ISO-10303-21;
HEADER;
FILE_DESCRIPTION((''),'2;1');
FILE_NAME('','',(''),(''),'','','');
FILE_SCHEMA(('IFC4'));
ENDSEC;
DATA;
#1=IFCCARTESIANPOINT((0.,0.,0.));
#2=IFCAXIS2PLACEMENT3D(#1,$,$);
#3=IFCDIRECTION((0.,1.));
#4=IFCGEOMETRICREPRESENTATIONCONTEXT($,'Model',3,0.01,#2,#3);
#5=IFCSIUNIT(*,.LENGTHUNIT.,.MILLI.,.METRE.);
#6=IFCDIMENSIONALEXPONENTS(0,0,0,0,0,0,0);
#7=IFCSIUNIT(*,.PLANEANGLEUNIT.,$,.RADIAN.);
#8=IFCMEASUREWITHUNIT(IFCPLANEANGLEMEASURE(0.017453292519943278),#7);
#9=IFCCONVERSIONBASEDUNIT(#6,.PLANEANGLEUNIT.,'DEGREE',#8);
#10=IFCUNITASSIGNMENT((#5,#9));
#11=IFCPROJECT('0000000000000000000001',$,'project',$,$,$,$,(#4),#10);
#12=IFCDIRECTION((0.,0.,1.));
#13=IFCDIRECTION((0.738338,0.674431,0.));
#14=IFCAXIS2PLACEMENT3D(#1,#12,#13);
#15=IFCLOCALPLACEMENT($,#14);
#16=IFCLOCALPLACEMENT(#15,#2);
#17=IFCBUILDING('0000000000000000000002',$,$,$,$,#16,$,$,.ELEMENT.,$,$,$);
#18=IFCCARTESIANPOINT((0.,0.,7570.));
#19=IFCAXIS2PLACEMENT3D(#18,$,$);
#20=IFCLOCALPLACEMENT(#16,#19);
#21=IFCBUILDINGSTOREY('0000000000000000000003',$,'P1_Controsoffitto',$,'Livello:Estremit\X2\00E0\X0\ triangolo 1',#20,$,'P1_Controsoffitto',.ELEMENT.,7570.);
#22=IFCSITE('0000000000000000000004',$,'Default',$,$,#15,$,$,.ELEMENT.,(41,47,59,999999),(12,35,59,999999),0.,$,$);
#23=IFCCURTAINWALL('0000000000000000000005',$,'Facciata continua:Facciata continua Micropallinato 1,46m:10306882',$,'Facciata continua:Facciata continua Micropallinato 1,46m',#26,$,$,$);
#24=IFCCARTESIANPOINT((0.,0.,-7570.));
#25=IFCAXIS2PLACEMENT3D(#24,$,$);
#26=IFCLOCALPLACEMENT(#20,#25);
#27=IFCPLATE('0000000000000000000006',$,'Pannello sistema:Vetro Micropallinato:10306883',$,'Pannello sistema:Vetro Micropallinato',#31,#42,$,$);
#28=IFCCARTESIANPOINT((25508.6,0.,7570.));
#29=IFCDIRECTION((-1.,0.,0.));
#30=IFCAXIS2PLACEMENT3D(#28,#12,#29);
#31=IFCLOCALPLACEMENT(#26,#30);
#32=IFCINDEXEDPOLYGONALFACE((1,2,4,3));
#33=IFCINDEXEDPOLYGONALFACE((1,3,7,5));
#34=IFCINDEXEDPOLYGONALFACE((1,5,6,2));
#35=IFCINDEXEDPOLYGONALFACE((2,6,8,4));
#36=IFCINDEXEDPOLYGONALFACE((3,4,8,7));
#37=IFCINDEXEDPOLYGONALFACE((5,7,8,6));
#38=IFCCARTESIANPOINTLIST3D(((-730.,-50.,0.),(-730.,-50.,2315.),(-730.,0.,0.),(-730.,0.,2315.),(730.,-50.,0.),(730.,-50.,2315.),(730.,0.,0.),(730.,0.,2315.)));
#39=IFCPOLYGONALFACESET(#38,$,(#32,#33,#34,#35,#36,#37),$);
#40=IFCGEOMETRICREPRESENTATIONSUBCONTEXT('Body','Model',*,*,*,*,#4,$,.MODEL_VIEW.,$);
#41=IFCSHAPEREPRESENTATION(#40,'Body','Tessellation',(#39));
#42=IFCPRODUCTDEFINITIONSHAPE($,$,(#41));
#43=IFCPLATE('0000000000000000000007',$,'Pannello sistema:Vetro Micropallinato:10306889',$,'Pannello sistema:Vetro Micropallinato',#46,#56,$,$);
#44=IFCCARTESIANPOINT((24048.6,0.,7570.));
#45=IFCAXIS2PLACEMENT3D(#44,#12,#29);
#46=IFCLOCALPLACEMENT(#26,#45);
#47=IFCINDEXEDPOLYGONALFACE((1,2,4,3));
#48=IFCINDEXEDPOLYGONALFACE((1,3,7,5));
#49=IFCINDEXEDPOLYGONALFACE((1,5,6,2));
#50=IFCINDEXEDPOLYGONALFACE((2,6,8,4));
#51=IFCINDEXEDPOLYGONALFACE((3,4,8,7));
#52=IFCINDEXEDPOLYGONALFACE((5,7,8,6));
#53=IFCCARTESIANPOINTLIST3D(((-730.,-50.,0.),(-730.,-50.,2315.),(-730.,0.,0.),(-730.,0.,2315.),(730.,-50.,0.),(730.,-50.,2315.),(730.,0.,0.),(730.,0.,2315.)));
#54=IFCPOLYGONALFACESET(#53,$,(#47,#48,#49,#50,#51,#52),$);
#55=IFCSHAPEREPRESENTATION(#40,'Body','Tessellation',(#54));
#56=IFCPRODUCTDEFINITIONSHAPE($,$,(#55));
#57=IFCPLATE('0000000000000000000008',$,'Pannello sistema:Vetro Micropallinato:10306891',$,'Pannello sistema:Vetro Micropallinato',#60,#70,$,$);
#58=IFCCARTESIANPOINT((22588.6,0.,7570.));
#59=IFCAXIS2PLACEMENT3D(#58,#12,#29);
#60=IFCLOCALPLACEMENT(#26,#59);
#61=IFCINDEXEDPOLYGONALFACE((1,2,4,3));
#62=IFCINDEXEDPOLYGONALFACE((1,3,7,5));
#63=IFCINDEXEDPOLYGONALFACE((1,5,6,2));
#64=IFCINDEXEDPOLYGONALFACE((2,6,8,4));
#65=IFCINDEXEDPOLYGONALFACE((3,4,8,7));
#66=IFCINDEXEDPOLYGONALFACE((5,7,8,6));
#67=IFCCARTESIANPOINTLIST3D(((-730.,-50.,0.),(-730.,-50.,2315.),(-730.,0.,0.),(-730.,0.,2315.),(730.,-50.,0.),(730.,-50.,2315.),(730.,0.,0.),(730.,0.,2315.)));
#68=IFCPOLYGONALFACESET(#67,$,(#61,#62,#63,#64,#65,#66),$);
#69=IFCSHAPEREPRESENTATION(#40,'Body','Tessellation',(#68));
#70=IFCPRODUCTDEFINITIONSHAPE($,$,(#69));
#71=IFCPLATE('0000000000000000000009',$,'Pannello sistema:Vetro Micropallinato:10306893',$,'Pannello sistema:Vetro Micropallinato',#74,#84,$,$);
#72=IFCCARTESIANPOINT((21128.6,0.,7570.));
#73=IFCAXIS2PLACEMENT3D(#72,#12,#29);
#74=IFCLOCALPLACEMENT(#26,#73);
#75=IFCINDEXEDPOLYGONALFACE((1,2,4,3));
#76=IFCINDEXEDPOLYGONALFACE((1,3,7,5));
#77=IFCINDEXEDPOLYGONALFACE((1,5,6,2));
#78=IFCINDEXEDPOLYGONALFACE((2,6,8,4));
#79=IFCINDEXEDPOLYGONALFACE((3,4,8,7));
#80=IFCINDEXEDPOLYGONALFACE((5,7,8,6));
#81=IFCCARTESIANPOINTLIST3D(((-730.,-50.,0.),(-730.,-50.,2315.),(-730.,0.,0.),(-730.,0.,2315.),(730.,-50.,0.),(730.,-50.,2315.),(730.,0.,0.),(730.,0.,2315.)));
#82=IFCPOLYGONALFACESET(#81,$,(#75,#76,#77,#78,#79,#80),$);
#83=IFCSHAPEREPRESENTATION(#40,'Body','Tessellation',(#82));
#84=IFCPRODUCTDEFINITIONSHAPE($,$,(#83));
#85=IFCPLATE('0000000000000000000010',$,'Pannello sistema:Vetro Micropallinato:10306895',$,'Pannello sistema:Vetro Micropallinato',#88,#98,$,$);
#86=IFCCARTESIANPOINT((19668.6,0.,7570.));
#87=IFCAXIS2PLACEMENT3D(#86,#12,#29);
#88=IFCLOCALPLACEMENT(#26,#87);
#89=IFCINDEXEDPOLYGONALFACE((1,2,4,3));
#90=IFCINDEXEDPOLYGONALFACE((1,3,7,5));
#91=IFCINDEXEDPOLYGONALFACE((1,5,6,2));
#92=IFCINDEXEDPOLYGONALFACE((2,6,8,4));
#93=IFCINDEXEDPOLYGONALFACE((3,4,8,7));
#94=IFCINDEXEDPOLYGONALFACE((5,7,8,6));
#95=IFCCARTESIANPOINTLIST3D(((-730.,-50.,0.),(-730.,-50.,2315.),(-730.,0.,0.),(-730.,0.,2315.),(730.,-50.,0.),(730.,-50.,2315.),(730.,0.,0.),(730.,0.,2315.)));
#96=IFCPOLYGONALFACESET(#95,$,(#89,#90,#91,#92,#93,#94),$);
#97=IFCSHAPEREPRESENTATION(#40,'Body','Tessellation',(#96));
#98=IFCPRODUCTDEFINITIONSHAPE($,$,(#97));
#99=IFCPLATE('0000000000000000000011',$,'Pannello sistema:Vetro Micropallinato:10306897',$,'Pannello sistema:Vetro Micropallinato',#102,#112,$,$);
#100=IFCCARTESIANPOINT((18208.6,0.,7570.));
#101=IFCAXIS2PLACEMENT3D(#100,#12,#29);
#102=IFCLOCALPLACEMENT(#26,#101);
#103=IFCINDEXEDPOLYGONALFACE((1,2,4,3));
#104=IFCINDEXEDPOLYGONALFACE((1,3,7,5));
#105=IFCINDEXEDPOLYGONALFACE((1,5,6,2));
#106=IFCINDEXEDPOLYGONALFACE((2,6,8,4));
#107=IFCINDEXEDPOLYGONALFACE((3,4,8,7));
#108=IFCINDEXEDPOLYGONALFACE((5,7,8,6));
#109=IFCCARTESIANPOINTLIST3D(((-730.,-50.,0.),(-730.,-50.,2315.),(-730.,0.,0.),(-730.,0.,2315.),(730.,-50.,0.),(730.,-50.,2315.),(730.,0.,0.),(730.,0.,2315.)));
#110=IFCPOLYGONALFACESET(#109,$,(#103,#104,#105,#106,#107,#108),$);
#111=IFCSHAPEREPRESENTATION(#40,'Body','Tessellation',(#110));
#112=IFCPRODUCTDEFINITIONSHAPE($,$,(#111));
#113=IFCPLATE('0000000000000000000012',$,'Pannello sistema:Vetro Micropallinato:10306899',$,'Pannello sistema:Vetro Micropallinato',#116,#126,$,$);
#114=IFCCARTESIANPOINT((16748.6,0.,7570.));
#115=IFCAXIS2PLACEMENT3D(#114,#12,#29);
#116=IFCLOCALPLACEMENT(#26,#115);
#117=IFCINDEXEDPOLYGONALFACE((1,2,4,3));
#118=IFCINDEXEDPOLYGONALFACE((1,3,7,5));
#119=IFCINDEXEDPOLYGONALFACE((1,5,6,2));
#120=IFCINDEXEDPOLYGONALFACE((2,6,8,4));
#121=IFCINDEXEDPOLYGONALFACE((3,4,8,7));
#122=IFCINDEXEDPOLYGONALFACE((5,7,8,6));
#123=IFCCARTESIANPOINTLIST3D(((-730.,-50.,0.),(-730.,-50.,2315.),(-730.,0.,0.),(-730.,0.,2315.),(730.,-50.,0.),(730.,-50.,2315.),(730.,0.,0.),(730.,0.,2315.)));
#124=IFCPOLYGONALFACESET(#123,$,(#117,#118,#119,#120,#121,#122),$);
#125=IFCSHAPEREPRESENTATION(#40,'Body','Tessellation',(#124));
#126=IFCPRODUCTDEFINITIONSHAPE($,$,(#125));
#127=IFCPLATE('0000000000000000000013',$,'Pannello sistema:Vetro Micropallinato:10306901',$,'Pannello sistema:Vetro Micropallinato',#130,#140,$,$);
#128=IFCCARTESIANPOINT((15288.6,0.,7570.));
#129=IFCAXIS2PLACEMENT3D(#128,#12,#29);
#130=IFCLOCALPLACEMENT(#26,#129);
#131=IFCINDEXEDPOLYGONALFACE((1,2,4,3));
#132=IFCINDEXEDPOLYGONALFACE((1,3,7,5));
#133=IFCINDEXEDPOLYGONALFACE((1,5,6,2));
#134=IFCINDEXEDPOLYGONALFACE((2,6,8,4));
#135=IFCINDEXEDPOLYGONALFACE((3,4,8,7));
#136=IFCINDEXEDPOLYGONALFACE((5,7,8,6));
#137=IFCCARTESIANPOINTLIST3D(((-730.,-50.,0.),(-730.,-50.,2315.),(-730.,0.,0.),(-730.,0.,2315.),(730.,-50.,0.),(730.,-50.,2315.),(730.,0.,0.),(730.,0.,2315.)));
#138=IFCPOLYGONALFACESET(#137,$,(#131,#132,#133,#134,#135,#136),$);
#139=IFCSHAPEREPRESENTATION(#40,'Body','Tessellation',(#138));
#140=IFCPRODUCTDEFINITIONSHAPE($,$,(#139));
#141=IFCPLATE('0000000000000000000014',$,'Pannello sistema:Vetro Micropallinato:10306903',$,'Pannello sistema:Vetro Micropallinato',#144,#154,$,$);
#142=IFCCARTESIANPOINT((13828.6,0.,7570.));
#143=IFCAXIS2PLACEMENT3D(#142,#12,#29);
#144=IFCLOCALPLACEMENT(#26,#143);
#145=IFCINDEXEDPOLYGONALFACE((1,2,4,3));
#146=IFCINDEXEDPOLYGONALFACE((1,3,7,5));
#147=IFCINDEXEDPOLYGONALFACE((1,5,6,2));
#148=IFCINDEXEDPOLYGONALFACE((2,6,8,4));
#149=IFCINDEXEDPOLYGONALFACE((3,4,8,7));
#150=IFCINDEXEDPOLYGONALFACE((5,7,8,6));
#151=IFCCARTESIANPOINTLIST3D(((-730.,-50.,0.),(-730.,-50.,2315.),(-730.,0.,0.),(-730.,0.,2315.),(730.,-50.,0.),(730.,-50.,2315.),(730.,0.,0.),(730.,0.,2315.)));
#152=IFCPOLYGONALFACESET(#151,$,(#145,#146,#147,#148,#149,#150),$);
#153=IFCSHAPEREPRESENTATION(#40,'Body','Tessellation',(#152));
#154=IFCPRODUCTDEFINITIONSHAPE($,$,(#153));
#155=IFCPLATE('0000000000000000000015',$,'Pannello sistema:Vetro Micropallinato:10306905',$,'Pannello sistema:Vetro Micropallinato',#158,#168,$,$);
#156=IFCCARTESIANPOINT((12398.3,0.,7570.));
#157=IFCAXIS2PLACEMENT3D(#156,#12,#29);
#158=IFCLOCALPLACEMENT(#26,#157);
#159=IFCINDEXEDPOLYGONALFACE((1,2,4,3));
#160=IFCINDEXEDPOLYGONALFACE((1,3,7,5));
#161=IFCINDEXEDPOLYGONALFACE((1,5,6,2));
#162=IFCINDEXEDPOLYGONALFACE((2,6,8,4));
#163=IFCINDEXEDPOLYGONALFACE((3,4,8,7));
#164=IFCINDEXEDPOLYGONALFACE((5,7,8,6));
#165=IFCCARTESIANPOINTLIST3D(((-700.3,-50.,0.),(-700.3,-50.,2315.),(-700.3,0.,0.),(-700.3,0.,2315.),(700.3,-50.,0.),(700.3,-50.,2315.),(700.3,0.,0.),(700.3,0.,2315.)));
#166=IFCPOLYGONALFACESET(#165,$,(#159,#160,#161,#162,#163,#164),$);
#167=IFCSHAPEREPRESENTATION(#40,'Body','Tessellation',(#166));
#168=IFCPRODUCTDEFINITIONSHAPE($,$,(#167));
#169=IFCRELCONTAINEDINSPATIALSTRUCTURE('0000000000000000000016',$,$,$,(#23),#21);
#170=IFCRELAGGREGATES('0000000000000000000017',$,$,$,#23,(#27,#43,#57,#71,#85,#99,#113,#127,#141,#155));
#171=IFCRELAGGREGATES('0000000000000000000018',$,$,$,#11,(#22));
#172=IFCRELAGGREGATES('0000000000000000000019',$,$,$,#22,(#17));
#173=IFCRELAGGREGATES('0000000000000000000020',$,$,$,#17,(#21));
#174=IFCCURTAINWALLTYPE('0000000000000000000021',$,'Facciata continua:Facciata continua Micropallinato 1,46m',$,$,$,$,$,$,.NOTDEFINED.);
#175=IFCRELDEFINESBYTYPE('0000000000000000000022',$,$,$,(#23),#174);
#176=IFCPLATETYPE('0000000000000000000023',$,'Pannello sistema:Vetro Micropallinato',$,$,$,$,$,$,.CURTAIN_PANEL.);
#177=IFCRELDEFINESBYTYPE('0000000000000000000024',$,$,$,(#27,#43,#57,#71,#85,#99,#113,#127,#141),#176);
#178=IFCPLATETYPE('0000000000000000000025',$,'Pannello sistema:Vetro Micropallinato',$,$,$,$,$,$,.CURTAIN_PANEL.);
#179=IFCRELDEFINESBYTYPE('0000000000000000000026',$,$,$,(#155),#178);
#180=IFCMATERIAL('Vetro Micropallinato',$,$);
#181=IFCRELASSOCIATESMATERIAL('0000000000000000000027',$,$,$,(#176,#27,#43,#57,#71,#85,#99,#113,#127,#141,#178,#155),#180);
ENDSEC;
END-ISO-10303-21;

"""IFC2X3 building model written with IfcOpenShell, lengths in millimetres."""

from ifc_helpers import new_model, entity, si_unit, converted_unit, direction, frame, origin, origin_2d_with_axis, place, context, subcontext, project, spatial, rectangle, extrude, source, transform, mapped, material, type_object, type_shapes, element, aggregate, save


model = new_model("IFC2X3")

# Units and contexts
model_context = context("Model", 3, precision=0.01, world=origin(), true_north=direction((0.0, 1.0)))
body_context = subcontext(model_context, "Body", "Model", "MODEL_VIEW")
ifc_project = project(units=[si_unit("LENGTHUNIT", "METRE", prefix="MILLI"), converted_unit("PLANEANGLEUNIT", "DEGREE", entity("IfcPlaneAngleMeasure", 0.017453292519943278), si_unit("PLANEANGLEUNIT", "RADIAN"), dimensions=[0, 0, 0, 0, 0, 0, 0])], contexts=[model_context])

# Site, building, storey
site_placement = place(None, frame((0.0, 0.0, 0.0), z_axis=(0.0, 0.0, 1.0), x_axis=(0.738338, 0.674431, 0.0)))
site = spatial("IfcSite", under=ifc_project, at=site_placement, Name="Default", CompositionType="ELEMENT", RefLatitude=(41, 47, 59, 999999), RefLongitude=(12, 35, 59, 999999), RefElevation=0.0)
building_placement = place(site_placement, origin())
building = spatial("IfcBuilding", under=site, at=building_placement, CompositionType="ELEMENT")
storey_placement = place(building_placement, frame((0.0, 0.0, 7570.0)))
storey = spatial("IfcBuildingStorey", under=building, at=storey_placement, Name="P1_Controsoffitto", ObjectType="Livello:Estremità triangolo 1", LongName="P1_Controsoffitto", CompositionType="ELEMENT", Elevation=7570.0)

# Curtain wall, plates
curtain_wall_type = type_object("IfcCurtainWallType", Name="Facciata continua:Facciata continua Micropallinato 1,46m", PredefinedType="NOTDEFINED")
curtain_wall_placement = place(storey_placement, frame((0.0, 0.0, -7570.0)))
curtain_wall = element("IfcCurtainWall", 1, at=curtain_wall_placement, inside=storey, type_object=curtain_wall_type, Name="Facciata continua:Facciata continua Micropallinato 1,46m:10306882", ObjectType="Facciata continua:Facciata continua Micropallinato 1,46m")
ifc_material_1 = material(Name="Vetro Micropallinato")
plate_type_1 = type_object("IfcPlateType", Name="Pannello sistema:Vetro Micropallinato", PredefinedType="CURTAIN_PANEL", material=ifc_material_1)
shared_shape_1 = source(origin(), body_context, "Body", "SweptSolid", [
    extrude(rectangle(XDim=50.0, YDim=1460.0, at=origin_2d_with_axis()), frame((0.0, -25.0, 0.0), z_axis=(0.0, 0.0, 1.0), x_axis=(0.0, 1.0, 0.0)), (0.0, 0.0, 1.0), 2315.0),
])
type_shapes(plate_type_1, [shared_shape_1])
plate_1_placement = place(curtain_wall_placement, frame((25508.6, 0.0, 7570.0), z_axis=(0.0, 0.0, 1.0), x_axis=(-1.0, 0.0, 0.0)))
plate_1 = element("IfcPlate", 2, at=plate_1_placement, type_object=plate_type_1, material=ifc_material_1, Name="Pannello sistema:Vetro Micropallinato:10306883", ObjectType="Pannello sistema:Vetro Micropallinato", context=body_context, shape_type="MappedRepresentation", body=[
    mapped(shared_shape_1, transform((0.0, 0.0, 0.0), scale=1.0)),
])
plate_2_placement = place(curtain_wall_placement, frame((24048.6, 0.0, 7570.0), z_axis=(0.0, 0.0, 1.0), x_axis=(-1.0, 0.0, 0.0)))
plate_2 = element("IfcPlate", 3, at=plate_2_placement, type_object=plate_type_1, material=ifc_material_1, Name="Pannello sistema:Vetro Micropallinato:10306889", ObjectType="Pannello sistema:Vetro Micropallinato", context=body_context, shape_type="MappedRepresentation", body=[
    mapped(shared_shape_1, transform((0.0, 0.0, 0.0), scale=1.0)),
])
plate_3_placement = place(curtain_wall_placement, frame((22588.6, 0.0, 7570.0), z_axis=(0.0, 0.0, 1.0), x_axis=(-1.0, 0.0, 0.0)))
plate_3 = element("IfcPlate", 4, at=plate_3_placement, type_object=plate_type_1, material=ifc_material_1, Name="Pannello sistema:Vetro Micropallinato:10306891", ObjectType="Pannello sistema:Vetro Micropallinato", context=body_context, shape_type="MappedRepresentation", body=[
    mapped(shared_shape_1, transform((0.0, 0.0, 0.0), scale=1.0)),
])
plate_4_placement = place(curtain_wall_placement, frame((21128.6, 0.0, 7570.0), z_axis=(0.0, 0.0, 1.0), x_axis=(-1.0, 0.0, 0.0)))
plate_4 = element("IfcPlate", 5, at=plate_4_placement, type_object=plate_type_1, material=ifc_material_1, Name="Pannello sistema:Vetro Micropallinato:10306893", ObjectType="Pannello sistema:Vetro Micropallinato", context=body_context, shape_type="MappedRepresentation", body=[
    mapped(shared_shape_1, transform((0.0, 0.0, 0.0), scale=1.0)),
])
plate_5_placement = place(curtain_wall_placement, frame((19668.6, 0.0, 7570.0), z_axis=(0.0, 0.0, 1.0), x_axis=(-1.0, 0.0, 0.0)))
plate_5 = element("IfcPlate", 6, at=plate_5_placement, type_object=plate_type_1, material=ifc_material_1, Name="Pannello sistema:Vetro Micropallinato:10306895", ObjectType="Pannello sistema:Vetro Micropallinato", context=body_context, shape_type="MappedRepresentation", body=[
    mapped(shared_shape_1, transform((0.0, 0.0, 0.0), scale=1.0)),
])
plate_6_placement = place(curtain_wall_placement, frame((18208.6, 0.0, 7570.0), z_axis=(0.0, 0.0, 1.0), x_axis=(-1.0, 0.0, 0.0)))
plate_6 = element("IfcPlate", 7, at=plate_6_placement, type_object=plate_type_1, material=ifc_material_1, Name="Pannello sistema:Vetro Micropallinato:10306897", ObjectType="Pannello sistema:Vetro Micropallinato", context=body_context, shape_type="MappedRepresentation", body=[
    mapped(shared_shape_1, transform((0.0, 0.0, 0.0), scale=1.0)),
])
plate_7_placement = place(curtain_wall_placement, frame((16748.6, 0.0, 7570.0), z_axis=(0.0, 0.0, 1.0), x_axis=(-1.0, 0.0, 0.0)))
plate_7 = element("IfcPlate", 8, at=plate_7_placement, type_object=plate_type_1, material=ifc_material_1, Name="Pannello sistema:Vetro Micropallinato:10306899", ObjectType="Pannello sistema:Vetro Micropallinato", context=body_context, shape_type="MappedRepresentation", body=[
    mapped(shared_shape_1, transform((0.0, 0.0, 0.0), scale=1.0)),
])
plate_8_placement = place(curtain_wall_placement, frame((15288.6, 0.0, 7570.0), z_axis=(0.0, 0.0, 1.0), x_axis=(-1.0, 0.0, 0.0)))
plate_8 = element("IfcPlate", 9, at=plate_8_placement, type_object=plate_type_1, material=ifc_material_1, Name="Pannello sistema:Vetro Micropallinato:10306901", ObjectType="Pannello sistema:Vetro Micropallinato", context=body_context, shape_type="MappedRepresentation", body=[
    mapped(shared_shape_1, transform((0.0, 0.0, 0.0), scale=1.0)),
])
plate_9_placement = place(curtain_wall_placement, frame((13828.6, 0.0, 7570.0), z_axis=(0.0, 0.0, 1.0), x_axis=(-1.0, 0.0, 0.0)))
plate_9 = element("IfcPlate", 10, at=plate_9_placement, type_object=plate_type_1, material=ifc_material_1, Name="Pannello sistema:Vetro Micropallinato:10306903", ObjectType="Pannello sistema:Vetro Micropallinato", context=body_context, shape_type="MappedRepresentation", body=[
    mapped(shared_shape_1, transform((0.0, 0.0, 0.0), scale=1.0)),
])
plate_type_2 = type_object("IfcPlateType", Name="Pannello sistema:Vetro Micropallinato", PredefinedType="CURTAIN_PANEL", material=ifc_material_1)
shared_shape_2 = source(origin(), body_context, "Body", "SweptSolid", [
    extrude(rectangle(XDim=50.0, YDim=1400.6, at=origin_2d_with_axis()), frame((0.0, -25.0, 0.0), z_axis=(0.0, 0.0, 1.0), x_axis=(0.0, 1.0, 0.0)), (0.0, 0.0, 1.0), 2315.0),
])
type_shapes(plate_type_2, [shared_shape_2])
plate_10_placement = place(curtain_wall_placement, frame((12398.3, 0.0, 7570.0), z_axis=(0.0, 0.0, 1.0), x_axis=(-1.0, 0.0, 0.0)))
plate_10 = element("IfcPlate", 11, at=plate_10_placement, type_object=plate_type_2, material=ifc_material_1, Name="Pannello sistema:Vetro Micropallinato:10306905", ObjectType="Pannello sistema:Vetro Micropallinato", context=body_context, shape_type="MappedRepresentation", body=[
    mapped(shared_shape_2, transform((0.0, 0.0, 0.0), scale=1.0)),
])
aggregate(curtain_wall, [plate_1, plate_2, plate_3, plate_4, plate_5, plate_6, plate_7, plate_8, plate_9, plate_10])

save(model, "model.ifc")
